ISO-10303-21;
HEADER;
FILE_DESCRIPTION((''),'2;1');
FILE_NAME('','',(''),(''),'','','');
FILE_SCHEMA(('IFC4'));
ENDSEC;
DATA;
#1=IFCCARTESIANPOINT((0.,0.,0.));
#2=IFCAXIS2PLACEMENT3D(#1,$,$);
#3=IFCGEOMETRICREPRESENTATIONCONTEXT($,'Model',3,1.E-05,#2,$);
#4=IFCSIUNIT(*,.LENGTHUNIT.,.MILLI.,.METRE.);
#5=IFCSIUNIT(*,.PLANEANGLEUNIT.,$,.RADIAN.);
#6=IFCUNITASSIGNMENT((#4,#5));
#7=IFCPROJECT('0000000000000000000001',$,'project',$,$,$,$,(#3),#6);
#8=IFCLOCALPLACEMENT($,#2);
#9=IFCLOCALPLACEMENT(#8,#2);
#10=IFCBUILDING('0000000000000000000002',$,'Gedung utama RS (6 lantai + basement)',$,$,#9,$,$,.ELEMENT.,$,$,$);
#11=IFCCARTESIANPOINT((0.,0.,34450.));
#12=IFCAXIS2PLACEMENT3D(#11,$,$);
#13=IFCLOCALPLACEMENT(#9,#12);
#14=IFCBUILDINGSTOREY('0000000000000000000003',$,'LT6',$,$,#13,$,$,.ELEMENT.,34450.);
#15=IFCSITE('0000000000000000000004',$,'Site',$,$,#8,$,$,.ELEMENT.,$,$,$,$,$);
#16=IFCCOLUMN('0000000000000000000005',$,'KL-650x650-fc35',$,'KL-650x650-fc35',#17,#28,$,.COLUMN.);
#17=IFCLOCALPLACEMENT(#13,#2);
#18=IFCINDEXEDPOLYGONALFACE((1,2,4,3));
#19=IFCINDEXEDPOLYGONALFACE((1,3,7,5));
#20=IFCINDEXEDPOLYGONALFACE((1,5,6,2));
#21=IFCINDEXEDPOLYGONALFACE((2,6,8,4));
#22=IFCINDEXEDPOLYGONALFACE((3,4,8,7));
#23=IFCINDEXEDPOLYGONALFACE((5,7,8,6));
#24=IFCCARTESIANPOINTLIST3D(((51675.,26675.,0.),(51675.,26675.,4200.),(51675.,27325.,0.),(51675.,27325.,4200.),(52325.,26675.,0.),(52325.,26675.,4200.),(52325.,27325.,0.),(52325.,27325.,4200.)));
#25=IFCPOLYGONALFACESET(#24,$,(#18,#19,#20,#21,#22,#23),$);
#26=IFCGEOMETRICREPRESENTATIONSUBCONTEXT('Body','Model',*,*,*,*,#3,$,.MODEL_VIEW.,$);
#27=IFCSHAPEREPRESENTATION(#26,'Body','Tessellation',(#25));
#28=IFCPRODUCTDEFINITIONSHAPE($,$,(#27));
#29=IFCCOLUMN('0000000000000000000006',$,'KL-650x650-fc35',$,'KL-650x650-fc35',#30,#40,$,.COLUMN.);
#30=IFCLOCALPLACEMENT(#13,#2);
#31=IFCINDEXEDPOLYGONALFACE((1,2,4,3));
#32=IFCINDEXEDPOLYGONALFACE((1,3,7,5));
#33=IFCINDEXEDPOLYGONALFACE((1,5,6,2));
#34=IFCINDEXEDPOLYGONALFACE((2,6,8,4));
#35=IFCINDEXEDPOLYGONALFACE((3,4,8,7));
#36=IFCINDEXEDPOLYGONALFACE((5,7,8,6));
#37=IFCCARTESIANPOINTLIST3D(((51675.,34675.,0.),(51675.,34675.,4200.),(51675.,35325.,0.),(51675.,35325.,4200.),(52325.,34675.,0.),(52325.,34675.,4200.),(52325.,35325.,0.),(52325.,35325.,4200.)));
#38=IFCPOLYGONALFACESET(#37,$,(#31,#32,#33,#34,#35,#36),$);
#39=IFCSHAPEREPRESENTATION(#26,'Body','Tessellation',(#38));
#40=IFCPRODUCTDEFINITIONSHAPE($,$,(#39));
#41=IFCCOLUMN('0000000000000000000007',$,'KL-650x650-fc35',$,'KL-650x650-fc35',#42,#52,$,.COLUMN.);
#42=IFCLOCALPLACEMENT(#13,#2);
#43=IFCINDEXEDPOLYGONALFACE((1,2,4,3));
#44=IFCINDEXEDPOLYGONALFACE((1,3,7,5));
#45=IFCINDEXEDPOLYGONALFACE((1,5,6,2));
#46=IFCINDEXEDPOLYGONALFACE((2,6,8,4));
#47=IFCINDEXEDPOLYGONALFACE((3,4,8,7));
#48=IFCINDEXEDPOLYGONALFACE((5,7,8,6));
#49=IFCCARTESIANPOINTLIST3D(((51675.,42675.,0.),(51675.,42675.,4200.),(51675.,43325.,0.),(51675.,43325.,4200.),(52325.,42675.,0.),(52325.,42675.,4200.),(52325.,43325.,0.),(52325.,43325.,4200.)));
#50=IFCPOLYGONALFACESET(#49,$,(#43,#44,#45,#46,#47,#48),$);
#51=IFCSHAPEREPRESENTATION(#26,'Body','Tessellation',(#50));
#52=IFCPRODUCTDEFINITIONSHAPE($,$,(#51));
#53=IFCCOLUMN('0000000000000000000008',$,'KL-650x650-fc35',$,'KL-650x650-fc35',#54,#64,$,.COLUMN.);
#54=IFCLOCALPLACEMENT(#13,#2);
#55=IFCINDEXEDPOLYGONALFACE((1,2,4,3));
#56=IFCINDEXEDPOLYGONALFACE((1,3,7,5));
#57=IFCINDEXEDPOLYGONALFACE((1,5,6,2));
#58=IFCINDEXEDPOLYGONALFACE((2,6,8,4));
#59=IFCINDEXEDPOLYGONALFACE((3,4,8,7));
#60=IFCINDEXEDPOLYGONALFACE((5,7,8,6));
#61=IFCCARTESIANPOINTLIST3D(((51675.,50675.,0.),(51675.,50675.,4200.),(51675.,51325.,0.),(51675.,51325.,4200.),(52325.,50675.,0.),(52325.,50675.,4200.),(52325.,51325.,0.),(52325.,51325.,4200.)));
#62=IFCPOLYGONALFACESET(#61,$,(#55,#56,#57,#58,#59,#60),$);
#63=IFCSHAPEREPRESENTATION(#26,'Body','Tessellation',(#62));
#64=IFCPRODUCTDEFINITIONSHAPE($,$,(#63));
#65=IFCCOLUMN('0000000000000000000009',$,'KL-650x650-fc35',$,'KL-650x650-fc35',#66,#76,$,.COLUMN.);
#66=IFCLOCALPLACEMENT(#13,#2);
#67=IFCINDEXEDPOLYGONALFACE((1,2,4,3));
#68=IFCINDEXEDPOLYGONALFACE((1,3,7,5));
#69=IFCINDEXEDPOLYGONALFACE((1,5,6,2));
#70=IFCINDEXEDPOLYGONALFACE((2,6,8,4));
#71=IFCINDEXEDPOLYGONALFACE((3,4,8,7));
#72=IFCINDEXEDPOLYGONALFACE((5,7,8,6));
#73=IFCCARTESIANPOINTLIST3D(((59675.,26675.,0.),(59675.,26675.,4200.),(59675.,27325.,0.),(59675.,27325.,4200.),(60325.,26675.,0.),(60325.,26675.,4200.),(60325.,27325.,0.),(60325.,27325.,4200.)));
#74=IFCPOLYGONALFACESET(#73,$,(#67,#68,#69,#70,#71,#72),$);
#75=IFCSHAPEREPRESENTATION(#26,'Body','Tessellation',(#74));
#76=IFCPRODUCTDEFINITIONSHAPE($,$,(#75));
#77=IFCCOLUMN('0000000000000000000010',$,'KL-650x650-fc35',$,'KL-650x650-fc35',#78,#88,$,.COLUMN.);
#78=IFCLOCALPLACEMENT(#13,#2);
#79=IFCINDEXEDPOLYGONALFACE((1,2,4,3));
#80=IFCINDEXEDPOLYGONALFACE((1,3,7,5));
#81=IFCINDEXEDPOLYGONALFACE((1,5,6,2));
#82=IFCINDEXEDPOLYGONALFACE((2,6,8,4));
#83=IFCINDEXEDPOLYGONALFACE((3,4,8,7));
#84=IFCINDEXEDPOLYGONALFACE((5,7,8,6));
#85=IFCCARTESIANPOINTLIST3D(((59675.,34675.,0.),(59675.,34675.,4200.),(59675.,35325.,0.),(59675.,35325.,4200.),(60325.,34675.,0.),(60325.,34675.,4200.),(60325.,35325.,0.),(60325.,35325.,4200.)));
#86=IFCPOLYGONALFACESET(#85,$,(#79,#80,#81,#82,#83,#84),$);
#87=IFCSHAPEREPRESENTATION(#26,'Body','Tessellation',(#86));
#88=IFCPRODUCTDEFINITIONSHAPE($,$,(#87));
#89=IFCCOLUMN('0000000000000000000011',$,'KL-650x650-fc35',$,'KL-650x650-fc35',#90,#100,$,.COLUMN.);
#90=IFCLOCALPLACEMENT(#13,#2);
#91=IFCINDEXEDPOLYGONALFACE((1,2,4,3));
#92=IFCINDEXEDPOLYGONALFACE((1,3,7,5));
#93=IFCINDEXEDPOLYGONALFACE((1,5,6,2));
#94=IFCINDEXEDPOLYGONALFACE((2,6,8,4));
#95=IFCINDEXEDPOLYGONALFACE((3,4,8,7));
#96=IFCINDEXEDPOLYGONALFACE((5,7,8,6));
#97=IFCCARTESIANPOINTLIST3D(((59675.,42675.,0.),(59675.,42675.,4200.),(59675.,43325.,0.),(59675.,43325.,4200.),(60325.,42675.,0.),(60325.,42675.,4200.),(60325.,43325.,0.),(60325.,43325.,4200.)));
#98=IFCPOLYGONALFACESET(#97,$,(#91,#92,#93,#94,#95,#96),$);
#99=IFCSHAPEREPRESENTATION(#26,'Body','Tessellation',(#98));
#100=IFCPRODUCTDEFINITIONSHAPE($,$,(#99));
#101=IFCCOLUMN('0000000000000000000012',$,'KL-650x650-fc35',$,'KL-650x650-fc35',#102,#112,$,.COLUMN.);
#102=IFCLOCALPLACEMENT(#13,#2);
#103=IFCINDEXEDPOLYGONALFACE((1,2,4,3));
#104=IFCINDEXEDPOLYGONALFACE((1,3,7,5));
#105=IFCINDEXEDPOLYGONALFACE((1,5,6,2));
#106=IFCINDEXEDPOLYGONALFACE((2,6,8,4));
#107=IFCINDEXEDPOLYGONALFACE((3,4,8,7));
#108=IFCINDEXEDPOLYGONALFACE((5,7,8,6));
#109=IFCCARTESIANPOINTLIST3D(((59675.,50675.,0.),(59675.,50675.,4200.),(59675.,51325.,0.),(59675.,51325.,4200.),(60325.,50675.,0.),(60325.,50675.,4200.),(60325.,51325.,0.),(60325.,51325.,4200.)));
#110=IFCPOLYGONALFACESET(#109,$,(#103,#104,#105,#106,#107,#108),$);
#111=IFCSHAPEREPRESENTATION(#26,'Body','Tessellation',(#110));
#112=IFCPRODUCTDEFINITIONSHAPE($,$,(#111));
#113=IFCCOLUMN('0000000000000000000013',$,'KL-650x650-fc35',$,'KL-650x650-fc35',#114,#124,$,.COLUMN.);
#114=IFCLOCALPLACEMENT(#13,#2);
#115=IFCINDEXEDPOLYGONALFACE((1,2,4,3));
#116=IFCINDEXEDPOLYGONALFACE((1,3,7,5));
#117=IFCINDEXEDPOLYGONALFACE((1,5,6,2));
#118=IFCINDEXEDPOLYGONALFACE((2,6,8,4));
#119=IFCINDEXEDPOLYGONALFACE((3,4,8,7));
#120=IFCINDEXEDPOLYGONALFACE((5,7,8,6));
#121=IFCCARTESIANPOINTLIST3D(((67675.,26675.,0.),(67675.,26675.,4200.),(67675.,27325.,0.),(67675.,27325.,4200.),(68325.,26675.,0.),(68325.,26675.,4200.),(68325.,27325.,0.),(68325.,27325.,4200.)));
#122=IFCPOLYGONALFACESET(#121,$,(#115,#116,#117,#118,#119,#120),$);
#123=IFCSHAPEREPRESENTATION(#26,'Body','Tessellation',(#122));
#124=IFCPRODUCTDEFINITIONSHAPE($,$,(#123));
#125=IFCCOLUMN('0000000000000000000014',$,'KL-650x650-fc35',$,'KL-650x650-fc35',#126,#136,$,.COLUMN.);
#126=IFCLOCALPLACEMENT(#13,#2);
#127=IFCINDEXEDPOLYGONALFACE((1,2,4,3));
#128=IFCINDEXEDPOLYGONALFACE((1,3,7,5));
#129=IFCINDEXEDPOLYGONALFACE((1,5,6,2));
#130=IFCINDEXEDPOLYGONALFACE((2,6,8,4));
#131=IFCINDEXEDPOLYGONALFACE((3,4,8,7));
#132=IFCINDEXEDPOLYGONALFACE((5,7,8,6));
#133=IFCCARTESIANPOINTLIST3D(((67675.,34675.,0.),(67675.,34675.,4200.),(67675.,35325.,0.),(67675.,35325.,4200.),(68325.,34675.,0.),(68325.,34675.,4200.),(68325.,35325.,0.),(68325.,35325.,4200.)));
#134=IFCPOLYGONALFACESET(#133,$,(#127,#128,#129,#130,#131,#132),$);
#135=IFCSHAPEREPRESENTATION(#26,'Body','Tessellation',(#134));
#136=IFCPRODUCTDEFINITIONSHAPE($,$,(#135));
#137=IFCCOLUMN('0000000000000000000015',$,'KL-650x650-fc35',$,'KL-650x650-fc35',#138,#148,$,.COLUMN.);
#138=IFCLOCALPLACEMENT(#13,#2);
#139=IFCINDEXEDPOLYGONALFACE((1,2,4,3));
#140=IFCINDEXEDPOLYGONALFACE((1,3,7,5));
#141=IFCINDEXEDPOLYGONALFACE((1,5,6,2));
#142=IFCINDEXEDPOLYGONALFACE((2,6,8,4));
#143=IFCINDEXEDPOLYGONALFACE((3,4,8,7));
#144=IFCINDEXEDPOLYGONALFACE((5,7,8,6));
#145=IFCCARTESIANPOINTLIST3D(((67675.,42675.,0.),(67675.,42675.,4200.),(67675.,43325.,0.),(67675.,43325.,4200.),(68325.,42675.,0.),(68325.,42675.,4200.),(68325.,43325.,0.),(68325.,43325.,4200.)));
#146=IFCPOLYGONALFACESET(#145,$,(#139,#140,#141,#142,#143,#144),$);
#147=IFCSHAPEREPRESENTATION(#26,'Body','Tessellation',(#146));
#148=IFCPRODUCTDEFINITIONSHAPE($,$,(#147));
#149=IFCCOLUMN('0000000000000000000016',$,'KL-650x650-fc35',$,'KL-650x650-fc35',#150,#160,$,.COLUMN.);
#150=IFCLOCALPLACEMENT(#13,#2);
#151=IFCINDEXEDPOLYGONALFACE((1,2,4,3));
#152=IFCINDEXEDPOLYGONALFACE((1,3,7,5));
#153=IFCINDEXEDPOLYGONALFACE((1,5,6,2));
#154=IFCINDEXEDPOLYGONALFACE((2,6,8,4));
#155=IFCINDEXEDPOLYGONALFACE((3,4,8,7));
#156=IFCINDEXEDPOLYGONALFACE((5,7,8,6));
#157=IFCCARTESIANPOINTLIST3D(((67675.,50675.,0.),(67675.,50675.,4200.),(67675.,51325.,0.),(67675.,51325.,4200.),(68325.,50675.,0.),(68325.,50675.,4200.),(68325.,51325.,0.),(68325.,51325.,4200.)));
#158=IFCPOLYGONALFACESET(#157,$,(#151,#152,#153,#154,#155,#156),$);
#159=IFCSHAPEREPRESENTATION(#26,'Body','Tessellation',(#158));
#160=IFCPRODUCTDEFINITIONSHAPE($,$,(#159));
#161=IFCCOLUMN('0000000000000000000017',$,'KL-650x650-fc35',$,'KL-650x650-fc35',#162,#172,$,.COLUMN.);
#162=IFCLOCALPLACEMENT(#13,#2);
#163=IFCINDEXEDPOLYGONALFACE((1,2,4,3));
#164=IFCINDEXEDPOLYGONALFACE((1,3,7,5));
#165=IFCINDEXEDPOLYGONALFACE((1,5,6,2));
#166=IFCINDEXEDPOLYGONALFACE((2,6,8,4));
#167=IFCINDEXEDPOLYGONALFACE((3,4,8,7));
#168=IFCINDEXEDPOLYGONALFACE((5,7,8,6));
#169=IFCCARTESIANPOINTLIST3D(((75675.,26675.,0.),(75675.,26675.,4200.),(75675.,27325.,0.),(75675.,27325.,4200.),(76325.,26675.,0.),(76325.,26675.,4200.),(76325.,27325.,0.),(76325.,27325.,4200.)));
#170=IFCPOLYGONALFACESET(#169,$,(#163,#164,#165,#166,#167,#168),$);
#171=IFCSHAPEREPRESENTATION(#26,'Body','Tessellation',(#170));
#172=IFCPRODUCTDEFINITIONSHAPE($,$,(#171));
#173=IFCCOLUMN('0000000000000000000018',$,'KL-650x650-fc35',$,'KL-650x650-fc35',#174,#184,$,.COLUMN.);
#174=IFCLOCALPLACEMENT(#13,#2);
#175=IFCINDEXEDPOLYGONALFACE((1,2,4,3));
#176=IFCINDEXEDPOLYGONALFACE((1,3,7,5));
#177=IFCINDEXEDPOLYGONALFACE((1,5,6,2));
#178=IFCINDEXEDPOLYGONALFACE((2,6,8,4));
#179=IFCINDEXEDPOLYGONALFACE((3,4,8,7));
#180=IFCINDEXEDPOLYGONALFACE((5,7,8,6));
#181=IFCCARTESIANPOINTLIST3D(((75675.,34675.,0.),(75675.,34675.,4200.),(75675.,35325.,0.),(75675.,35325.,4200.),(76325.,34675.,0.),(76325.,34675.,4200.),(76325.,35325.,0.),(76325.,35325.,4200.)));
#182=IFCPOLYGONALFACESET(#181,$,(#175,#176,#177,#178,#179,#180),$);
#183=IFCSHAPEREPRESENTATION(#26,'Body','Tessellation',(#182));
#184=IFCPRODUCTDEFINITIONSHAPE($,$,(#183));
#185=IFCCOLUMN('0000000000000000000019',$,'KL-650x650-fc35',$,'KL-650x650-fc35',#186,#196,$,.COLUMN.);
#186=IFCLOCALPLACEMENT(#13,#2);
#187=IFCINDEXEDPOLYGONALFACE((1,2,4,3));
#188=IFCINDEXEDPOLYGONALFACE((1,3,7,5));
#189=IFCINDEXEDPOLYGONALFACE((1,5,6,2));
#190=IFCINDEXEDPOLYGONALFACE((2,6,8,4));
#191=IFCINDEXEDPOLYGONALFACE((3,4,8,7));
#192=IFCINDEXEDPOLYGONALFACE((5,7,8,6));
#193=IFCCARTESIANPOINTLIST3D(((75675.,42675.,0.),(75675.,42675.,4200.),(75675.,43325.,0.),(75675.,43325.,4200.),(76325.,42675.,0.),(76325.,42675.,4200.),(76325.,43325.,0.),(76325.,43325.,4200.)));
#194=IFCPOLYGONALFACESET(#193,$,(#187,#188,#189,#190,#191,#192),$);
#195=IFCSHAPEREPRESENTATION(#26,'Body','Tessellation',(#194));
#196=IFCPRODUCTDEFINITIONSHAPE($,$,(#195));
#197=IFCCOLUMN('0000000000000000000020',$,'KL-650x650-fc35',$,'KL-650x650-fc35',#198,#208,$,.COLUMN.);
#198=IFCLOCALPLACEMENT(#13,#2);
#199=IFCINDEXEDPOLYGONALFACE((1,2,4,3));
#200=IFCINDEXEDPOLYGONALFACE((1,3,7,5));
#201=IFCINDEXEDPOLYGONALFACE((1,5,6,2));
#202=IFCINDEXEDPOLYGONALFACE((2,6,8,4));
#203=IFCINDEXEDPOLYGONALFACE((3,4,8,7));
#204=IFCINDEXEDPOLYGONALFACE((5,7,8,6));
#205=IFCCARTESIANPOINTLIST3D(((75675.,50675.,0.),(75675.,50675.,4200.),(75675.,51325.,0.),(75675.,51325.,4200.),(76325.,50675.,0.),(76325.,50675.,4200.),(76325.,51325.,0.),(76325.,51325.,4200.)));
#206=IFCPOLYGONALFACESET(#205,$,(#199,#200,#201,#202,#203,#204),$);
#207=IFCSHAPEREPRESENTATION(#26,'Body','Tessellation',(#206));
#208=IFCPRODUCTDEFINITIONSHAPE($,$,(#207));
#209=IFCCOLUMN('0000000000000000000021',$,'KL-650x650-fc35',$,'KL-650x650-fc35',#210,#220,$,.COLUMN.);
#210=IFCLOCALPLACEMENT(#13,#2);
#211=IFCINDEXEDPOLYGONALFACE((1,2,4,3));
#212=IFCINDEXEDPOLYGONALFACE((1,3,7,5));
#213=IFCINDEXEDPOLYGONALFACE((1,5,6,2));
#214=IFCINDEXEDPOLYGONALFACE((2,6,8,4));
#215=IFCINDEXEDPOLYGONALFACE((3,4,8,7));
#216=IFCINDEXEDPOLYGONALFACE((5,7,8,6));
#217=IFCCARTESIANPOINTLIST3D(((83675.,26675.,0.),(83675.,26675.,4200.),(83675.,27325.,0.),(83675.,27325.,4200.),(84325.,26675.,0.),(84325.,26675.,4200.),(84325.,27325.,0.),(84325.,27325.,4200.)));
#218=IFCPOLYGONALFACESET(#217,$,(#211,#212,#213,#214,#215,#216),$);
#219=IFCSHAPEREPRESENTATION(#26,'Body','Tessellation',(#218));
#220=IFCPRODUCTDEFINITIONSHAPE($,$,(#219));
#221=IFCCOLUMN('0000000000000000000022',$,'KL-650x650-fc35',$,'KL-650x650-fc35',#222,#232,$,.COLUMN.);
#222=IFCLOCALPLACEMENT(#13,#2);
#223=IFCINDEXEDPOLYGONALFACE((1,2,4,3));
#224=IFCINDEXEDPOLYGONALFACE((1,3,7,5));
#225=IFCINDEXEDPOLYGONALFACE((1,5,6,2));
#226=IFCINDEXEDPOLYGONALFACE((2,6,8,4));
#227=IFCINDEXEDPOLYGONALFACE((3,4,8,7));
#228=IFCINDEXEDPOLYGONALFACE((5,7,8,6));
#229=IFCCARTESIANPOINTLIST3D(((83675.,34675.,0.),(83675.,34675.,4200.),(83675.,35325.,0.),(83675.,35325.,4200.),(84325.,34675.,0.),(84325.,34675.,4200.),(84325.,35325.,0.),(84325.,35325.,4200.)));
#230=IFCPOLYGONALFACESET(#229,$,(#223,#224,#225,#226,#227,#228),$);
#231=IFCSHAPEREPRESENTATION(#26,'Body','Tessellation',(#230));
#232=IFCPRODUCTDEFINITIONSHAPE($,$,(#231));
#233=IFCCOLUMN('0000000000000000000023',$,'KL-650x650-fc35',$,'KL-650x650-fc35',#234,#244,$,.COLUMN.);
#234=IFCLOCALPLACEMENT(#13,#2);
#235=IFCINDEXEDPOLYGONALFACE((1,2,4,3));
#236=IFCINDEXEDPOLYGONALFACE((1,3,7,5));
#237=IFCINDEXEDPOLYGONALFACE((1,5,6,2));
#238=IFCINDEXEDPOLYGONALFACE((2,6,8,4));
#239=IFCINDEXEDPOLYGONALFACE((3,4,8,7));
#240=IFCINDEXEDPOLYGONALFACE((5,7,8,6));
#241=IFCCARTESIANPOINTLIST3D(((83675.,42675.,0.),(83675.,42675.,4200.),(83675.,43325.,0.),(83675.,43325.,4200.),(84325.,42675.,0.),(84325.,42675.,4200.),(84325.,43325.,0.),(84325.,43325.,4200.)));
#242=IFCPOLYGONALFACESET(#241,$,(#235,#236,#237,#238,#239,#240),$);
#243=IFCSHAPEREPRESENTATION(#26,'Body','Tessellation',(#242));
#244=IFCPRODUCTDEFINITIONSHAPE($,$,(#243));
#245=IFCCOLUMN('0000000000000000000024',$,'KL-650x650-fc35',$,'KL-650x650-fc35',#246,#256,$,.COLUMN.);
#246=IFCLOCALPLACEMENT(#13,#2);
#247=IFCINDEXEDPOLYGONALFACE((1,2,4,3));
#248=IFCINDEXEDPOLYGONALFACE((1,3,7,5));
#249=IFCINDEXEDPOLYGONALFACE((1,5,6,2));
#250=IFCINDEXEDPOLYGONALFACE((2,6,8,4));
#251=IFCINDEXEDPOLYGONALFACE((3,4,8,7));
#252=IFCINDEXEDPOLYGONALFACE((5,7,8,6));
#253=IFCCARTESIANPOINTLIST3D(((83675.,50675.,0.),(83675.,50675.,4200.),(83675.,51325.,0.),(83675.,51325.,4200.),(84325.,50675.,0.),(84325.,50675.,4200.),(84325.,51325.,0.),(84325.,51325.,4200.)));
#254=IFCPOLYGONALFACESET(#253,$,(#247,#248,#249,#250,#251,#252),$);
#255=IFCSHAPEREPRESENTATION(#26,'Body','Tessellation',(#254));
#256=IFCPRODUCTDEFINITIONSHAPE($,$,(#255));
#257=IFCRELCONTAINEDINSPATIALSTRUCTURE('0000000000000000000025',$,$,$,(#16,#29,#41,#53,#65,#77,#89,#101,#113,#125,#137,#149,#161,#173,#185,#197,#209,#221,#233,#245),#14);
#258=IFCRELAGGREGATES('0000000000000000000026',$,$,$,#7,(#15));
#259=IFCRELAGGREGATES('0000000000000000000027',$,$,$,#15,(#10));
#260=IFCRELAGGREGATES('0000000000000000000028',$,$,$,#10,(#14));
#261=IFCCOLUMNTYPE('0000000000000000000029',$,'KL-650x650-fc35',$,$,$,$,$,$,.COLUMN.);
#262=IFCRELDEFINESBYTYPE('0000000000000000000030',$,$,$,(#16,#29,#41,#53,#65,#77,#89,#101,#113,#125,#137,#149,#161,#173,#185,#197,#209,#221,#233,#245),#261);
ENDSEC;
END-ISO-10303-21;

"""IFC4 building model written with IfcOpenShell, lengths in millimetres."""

from ifc_helpers import new_model, si_unit, frame, origin, origin_2d, place, context, subcontext, project, spatial, rectangle, extrude, material_profile, profile_set, profile_usage, type_object, element, save


model = new_model("IFC4")

# Units and contexts
model_context = context("Model", 3, precision=1e-05, world=origin())
body_context = subcontext(model_context, "Body", "Model", "MODEL_VIEW")
ifc_project = project(units=[si_unit("LENGTHUNIT", "METRE", prefix="MILLI"), si_unit("PLANEANGLEUNIT", "RADIAN")], contexts=[model_context])

# Site, building, storey
site_placement = place(None, origin())
site = spatial("IfcSite", under=ifc_project, at=site_placement, Name="Site", CompositionType="ELEMENT")
building_placement = place(site_placement, origin())
building = spatial("IfcBuilding", under=site, at=building_placement, Name="Gedung utama RS (6 lantai + basement)", CompositionType="ELEMENT")
storey_placement = place(building_placement, frame((0.0, 0.0, 34450.0)))
storey = spatial("IfcBuildingStorey", under=building, at=storey_placement, Name="LT6", CompositionType="ELEMENT", Elevation=34450.0)

# Columns
ifc_material_profile_1 = material_profile(None, rectangle(XDim=650.0, YDim=650.0, at=origin_2d()), Name="KL-650x650-fc35")
ifc_profile_set_1 = profile_set([ifc_material_profile_1], Name="KL-650x650-fc35")
ifc_profile_usage_1 = profile_usage(ifc_profile_set_1, cardinal=5)
column_type = type_object("IfcColumnType", Name="KL-650x650-fc35", PredefinedType="COLUMN", material=ifc_profile_set_1)
for number, where, z_axis, x_axis, name in (
    (1, (52000.0, 27000.0, 0.0), (0.0, 0.0, 1.0), (1.0, 0.0, 0.0), "KL-650x650-fc35"),
    (2, (52000.0, 35000.0, 0.0), (0.0, 0.0, 1.0), (1.0, 0.0, 0.0), "KL-650x650-fc35"),
    (3, (52000.0, 43000.0, 0.0), (0.0, 0.0, 1.0), (1.0, 0.0, 0.0), "KL-650x650-fc35"),
    (4, (52000.0, 51000.0, 0.0), (0.0, 0.0, 1.0), (1.0, 0.0, 0.0), "KL-650x650-fc35"),
    (5, (60000.0, 27000.0, 0.0), (0.0, 0.0, 1.0), (1.0, 0.0, 0.0), "KL-650x650-fc35"),
    (6, (60000.0, 35000.0, 0.0), (0.0, 0.0, 1.0), (1.0, 0.0, 0.0), "KL-650x650-fc35"),
    (7, (60000.0, 43000.0, 0.0), (0.0, 0.0, 1.0), (1.0, 0.0, 0.0), "KL-650x650-fc35"),
    (8, (60000.0, 51000.0, 0.0), (0.0, 0.0, 1.0), (1.0, 0.0, 0.0), "KL-650x650-fc35"),
    (9, (68000.0, 27000.0, 0.0), (0.0, 0.0, 1.0), (1.0, 0.0, 0.0), "KL-650x650-fc35"),
    (10, (68000.0, 35000.0, 0.0), (0.0, 0.0, 1.0), (1.0, 0.0, 0.0), "KL-650x650-fc35"),
    (11, (68000.0, 43000.0, 0.0), (0.0, 0.0, 1.0), (1.0, 0.0, 0.0), "KL-650x650-fc35"),
    (12, (68000.0, 51000.0, 0.0), (0.0, 0.0, 1.0), (1.0, 0.0, 0.0), "KL-650x650-fc35"),
    (13, (76000.0, 27000.0, 0.0), (0.0, 0.0, 1.0), (1.0, 0.0, 0.0), "KL-650x650-fc35"),
    (14, (76000.0, 35000.0, 0.0), (0.0, 0.0, 1.0), (1.0, 0.0, 0.0), "KL-650x650-fc35"),
    (15, (76000.0, 43000.0, 0.0), (0.0, 0.0, 1.0), (1.0, 0.0, 0.0), "KL-650x650-fc35"),
    (16, (76000.0, 51000.0, 0.0), (0.0, 0.0, 1.0), (1.0, 0.0, 0.0), "KL-650x650-fc35"),
    (17, (84000.0, 27000.0, 0.0), (0.0, 0.0, 1.0), (1.0, 0.0, 0.0), "KL-650x650-fc35"),
    (18, (84000.0, 35000.0, 0.0), (0.0, 0.0, 1.0), (1.0, 0.0, 0.0), "KL-650x650-fc35"),
    (19, (84000.0, 43000.0, 0.0), (0.0, 0.0, 1.0), (1.0, 0.0, 0.0), "KL-650x650-fc35"),
    (20, (84000.0, 51000.0, 0.0), (0.0, 0.0, 1.0), (1.0, 0.0, 0.0), "KL-650x650-fc35"),
):
    element("IfcColumn", number, at=place(storey_placement, frame(where, z_axis=z_axis, x_axis=x_axis)), inside=storey, type_object=column_type, material=ifc_profile_usage_1, Name=name, ObjectType="KL-650x650-fc35", PredefinedType="COLUMN", context=body_context, shape_type="SweptSolid", body=[
        extrude(rectangle(XDim=650.0, YDim=650.0, at=origin_2d()), origin(), (0.0, 0.0, 1.0), 4200.0),
    ])

save(model, "model.ifc")
